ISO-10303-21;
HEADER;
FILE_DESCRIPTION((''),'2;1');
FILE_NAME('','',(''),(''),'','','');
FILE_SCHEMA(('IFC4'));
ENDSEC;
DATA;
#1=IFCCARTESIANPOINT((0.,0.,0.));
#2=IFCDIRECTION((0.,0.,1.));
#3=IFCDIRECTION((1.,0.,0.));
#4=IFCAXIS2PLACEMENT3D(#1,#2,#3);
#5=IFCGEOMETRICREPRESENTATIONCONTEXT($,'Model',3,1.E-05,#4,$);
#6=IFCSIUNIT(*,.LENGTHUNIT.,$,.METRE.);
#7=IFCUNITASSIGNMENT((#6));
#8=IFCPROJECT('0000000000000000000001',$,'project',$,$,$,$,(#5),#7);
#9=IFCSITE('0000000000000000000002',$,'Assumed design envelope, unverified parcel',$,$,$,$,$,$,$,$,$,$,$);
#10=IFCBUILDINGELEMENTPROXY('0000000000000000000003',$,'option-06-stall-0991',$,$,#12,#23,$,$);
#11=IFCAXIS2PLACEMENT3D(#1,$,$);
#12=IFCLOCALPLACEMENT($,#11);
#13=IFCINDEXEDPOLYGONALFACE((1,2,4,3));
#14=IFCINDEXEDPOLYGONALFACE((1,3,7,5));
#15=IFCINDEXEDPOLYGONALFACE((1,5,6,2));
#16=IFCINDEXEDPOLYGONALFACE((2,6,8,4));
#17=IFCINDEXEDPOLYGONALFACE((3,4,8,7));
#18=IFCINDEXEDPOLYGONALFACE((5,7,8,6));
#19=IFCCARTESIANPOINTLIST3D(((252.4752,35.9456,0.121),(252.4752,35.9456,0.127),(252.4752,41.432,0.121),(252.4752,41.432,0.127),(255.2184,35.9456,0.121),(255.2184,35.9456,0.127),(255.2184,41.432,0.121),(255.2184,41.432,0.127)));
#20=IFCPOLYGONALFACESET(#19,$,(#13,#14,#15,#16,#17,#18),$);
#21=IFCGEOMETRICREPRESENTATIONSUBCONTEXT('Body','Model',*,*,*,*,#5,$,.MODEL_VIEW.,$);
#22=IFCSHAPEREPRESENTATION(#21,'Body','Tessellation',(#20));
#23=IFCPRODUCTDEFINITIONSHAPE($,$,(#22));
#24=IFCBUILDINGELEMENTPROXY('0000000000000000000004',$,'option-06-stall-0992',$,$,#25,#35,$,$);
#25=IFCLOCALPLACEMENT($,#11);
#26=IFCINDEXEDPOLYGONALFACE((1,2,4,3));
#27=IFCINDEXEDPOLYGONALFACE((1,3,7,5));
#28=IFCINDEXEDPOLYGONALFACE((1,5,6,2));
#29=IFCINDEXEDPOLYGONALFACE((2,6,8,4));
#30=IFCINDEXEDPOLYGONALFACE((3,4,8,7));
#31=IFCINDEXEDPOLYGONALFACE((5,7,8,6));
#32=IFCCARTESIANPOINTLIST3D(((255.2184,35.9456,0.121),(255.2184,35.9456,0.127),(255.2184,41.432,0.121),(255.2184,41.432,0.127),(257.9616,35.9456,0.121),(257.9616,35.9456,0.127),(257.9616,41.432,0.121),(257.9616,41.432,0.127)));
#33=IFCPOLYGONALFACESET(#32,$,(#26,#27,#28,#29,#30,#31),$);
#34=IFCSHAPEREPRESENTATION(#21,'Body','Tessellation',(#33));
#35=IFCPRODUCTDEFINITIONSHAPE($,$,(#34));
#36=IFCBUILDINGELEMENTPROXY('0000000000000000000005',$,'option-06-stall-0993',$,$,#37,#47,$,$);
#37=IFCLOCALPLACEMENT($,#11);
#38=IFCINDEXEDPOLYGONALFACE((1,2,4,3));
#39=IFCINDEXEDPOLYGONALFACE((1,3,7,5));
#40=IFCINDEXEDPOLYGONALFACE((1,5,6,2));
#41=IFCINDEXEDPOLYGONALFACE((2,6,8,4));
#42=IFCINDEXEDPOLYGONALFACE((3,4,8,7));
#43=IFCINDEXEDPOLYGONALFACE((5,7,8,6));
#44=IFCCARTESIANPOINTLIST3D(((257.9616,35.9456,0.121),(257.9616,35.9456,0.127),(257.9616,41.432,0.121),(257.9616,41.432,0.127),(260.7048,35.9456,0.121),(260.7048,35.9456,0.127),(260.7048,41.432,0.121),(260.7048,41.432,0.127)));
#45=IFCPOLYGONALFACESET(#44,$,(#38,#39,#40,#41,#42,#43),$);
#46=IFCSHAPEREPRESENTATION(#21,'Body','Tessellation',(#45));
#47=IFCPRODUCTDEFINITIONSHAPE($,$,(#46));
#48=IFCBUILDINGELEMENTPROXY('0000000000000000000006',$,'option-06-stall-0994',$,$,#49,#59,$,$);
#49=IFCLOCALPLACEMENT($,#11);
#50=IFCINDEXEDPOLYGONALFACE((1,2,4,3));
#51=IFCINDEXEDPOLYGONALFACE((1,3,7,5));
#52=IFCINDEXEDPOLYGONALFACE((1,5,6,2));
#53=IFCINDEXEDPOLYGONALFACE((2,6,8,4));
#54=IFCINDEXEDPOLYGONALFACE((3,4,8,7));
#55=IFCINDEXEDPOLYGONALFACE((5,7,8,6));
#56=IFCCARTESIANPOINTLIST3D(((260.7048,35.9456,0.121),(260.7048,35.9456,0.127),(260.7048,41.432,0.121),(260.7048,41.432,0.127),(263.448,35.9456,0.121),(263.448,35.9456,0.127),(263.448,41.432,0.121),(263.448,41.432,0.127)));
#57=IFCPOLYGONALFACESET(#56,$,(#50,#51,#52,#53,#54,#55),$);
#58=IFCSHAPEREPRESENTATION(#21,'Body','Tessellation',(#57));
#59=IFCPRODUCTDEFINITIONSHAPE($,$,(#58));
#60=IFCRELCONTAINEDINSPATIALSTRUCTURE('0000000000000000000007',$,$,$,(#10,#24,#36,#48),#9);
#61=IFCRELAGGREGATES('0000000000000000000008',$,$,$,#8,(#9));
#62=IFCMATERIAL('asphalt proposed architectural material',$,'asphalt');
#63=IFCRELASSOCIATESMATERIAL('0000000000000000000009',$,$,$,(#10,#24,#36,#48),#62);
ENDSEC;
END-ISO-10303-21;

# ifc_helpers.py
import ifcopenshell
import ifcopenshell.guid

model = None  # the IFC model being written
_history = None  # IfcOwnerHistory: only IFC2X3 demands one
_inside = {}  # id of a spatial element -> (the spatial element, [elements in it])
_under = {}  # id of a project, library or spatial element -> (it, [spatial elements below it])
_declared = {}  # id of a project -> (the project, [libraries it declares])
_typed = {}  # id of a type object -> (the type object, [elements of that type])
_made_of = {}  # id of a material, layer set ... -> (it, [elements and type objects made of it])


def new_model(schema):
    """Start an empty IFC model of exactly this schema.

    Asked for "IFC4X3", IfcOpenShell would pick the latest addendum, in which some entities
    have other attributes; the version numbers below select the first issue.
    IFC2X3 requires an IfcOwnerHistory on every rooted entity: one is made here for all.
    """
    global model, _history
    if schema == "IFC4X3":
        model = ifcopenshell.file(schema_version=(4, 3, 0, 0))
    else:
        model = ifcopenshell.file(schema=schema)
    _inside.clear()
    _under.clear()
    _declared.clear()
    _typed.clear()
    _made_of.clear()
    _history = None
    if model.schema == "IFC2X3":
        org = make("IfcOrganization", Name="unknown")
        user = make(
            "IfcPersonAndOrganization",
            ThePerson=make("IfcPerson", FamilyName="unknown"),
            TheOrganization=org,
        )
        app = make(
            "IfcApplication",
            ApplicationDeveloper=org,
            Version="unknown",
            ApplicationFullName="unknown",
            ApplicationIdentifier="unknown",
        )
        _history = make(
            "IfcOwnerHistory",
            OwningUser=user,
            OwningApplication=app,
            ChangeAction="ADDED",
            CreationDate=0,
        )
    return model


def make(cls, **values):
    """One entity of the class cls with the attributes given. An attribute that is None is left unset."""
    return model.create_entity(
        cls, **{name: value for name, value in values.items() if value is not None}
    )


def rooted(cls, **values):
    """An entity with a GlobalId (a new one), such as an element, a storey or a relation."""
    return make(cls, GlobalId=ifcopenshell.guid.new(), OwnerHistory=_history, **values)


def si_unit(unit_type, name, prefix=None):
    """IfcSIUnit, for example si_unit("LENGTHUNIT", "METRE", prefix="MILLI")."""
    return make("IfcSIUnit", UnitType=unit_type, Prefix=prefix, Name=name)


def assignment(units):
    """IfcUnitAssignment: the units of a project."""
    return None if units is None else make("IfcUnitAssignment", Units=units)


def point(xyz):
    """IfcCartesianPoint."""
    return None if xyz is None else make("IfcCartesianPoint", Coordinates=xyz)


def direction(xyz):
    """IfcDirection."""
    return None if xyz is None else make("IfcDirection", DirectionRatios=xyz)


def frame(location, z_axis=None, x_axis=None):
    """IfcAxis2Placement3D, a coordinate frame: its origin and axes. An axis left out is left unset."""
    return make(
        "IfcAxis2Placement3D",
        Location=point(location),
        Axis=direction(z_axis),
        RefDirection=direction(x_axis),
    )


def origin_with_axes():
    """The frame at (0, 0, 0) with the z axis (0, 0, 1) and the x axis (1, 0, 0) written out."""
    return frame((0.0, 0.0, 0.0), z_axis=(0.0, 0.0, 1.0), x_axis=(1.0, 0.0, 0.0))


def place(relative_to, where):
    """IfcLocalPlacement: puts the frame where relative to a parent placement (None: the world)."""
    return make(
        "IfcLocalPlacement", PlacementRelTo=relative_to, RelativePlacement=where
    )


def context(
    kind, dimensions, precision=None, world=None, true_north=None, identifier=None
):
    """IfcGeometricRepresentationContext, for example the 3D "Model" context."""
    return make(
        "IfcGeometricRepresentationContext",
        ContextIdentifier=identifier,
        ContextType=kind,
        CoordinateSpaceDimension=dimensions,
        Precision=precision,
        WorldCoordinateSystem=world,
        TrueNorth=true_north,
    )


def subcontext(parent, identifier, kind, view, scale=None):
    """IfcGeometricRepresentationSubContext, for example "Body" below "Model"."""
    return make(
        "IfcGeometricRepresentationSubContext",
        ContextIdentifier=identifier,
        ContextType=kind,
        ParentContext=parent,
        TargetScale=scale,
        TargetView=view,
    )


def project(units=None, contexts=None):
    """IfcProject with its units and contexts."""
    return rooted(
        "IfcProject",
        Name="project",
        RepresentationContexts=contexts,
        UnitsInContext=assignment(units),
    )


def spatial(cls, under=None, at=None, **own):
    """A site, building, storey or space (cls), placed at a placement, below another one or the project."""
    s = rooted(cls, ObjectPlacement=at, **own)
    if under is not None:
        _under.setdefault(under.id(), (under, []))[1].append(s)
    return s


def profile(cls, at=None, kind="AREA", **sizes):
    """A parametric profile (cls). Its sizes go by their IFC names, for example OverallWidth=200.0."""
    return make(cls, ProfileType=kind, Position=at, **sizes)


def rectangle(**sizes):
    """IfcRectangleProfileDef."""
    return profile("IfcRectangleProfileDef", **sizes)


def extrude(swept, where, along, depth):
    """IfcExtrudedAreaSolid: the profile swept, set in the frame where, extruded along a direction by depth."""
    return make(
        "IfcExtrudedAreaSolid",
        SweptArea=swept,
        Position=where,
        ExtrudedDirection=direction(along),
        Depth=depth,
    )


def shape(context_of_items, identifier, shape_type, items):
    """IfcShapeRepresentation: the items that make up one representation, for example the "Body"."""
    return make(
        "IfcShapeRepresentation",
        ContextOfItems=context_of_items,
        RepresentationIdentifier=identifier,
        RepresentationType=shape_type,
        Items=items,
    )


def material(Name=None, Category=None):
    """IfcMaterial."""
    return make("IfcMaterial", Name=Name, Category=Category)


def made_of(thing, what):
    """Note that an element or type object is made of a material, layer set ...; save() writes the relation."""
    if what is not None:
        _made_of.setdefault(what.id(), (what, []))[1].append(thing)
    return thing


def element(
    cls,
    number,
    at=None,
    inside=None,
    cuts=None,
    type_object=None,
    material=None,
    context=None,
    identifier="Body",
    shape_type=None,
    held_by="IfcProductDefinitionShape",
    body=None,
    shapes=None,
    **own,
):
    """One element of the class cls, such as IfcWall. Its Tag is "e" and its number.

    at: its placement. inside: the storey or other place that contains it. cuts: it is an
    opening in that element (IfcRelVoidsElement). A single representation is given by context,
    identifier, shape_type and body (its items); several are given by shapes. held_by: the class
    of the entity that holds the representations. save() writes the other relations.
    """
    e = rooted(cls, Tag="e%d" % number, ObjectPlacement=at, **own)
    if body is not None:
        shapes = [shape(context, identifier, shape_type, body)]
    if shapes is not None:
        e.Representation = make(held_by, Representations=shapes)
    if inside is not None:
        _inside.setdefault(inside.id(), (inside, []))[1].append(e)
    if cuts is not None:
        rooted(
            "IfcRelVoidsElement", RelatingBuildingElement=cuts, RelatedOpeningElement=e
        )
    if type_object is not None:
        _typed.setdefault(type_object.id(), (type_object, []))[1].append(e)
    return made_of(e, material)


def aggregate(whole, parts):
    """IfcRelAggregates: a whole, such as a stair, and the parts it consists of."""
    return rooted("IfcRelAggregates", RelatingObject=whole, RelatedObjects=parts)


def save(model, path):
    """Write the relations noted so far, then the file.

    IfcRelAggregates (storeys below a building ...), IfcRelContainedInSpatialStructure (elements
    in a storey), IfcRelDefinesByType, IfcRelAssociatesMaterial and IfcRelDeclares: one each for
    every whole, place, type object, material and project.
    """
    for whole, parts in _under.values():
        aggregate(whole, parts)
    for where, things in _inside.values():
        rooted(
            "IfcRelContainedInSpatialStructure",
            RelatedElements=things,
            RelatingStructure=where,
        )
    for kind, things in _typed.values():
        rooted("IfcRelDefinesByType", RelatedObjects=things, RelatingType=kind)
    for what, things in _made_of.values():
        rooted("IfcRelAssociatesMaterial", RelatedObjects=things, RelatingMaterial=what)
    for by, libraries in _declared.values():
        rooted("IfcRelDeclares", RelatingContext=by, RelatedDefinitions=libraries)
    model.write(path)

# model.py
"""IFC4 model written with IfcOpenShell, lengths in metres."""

from ifc_helpers import new_model, si_unit, frame, origin_with_axes, place, context, subcontext, project, spatial, rectangle, extrude, material, element, save


model = new_model("IFC4")

# Units and contexts
model_context = context("Model", 3, precision=1e-05, world=origin_with_axes())
body_context = subcontext(model_context, "Body", "Model", "MODEL_VIEW")
ifc_project = project(units=[si_unit("LENGTHUNIT", "METRE")], contexts=[model_context])

# Site
site = spatial("IfcSite", under=ifc_project, Name="Assumed design envelope, unverified parcel")

# Building element proxies
ifc_material = material(Name="asphalt proposed architectural material", Category="asphalt")
for number, where, z_axis, x_axis, name in (
    (1, (253.8468, 38.6888, 0.121), (0.0, 0.0, 1.0), (1.0, 0.0, 0.0), "option-06-stall-0991"),
    (2, (256.59, 38.6888, 0.121), (0.0, 0.0, 1.0), (1.0, 0.0, 0.0), "option-06-stall-0992"),
    (3, (259.3332, 38.6888, 0.121), (0.0, 0.0, 1.0), (1.0, 0.0, 0.0), "option-06-stall-0993"),
    (4, (262.0764, 38.6888, 0.121), (0.0, 0.0, 1.0), (1.0, 0.0, 0.0), "option-06-stall-0994"),
):
    element("IfcBuildingElementProxy", number, at=place(None, frame(where, z_axis=z_axis, x_axis=x_axis)), inside=site, material=ifc_material, Name=name, context=body_context, shape_type="SweptSolid", body=[
        extrude(rectangle(XDim=2.7432, YDim=5.4864), origin_with_axes(), (0.0, 0.0, 1.0), 0.006),
    ])

save(model, "model.ifc")
